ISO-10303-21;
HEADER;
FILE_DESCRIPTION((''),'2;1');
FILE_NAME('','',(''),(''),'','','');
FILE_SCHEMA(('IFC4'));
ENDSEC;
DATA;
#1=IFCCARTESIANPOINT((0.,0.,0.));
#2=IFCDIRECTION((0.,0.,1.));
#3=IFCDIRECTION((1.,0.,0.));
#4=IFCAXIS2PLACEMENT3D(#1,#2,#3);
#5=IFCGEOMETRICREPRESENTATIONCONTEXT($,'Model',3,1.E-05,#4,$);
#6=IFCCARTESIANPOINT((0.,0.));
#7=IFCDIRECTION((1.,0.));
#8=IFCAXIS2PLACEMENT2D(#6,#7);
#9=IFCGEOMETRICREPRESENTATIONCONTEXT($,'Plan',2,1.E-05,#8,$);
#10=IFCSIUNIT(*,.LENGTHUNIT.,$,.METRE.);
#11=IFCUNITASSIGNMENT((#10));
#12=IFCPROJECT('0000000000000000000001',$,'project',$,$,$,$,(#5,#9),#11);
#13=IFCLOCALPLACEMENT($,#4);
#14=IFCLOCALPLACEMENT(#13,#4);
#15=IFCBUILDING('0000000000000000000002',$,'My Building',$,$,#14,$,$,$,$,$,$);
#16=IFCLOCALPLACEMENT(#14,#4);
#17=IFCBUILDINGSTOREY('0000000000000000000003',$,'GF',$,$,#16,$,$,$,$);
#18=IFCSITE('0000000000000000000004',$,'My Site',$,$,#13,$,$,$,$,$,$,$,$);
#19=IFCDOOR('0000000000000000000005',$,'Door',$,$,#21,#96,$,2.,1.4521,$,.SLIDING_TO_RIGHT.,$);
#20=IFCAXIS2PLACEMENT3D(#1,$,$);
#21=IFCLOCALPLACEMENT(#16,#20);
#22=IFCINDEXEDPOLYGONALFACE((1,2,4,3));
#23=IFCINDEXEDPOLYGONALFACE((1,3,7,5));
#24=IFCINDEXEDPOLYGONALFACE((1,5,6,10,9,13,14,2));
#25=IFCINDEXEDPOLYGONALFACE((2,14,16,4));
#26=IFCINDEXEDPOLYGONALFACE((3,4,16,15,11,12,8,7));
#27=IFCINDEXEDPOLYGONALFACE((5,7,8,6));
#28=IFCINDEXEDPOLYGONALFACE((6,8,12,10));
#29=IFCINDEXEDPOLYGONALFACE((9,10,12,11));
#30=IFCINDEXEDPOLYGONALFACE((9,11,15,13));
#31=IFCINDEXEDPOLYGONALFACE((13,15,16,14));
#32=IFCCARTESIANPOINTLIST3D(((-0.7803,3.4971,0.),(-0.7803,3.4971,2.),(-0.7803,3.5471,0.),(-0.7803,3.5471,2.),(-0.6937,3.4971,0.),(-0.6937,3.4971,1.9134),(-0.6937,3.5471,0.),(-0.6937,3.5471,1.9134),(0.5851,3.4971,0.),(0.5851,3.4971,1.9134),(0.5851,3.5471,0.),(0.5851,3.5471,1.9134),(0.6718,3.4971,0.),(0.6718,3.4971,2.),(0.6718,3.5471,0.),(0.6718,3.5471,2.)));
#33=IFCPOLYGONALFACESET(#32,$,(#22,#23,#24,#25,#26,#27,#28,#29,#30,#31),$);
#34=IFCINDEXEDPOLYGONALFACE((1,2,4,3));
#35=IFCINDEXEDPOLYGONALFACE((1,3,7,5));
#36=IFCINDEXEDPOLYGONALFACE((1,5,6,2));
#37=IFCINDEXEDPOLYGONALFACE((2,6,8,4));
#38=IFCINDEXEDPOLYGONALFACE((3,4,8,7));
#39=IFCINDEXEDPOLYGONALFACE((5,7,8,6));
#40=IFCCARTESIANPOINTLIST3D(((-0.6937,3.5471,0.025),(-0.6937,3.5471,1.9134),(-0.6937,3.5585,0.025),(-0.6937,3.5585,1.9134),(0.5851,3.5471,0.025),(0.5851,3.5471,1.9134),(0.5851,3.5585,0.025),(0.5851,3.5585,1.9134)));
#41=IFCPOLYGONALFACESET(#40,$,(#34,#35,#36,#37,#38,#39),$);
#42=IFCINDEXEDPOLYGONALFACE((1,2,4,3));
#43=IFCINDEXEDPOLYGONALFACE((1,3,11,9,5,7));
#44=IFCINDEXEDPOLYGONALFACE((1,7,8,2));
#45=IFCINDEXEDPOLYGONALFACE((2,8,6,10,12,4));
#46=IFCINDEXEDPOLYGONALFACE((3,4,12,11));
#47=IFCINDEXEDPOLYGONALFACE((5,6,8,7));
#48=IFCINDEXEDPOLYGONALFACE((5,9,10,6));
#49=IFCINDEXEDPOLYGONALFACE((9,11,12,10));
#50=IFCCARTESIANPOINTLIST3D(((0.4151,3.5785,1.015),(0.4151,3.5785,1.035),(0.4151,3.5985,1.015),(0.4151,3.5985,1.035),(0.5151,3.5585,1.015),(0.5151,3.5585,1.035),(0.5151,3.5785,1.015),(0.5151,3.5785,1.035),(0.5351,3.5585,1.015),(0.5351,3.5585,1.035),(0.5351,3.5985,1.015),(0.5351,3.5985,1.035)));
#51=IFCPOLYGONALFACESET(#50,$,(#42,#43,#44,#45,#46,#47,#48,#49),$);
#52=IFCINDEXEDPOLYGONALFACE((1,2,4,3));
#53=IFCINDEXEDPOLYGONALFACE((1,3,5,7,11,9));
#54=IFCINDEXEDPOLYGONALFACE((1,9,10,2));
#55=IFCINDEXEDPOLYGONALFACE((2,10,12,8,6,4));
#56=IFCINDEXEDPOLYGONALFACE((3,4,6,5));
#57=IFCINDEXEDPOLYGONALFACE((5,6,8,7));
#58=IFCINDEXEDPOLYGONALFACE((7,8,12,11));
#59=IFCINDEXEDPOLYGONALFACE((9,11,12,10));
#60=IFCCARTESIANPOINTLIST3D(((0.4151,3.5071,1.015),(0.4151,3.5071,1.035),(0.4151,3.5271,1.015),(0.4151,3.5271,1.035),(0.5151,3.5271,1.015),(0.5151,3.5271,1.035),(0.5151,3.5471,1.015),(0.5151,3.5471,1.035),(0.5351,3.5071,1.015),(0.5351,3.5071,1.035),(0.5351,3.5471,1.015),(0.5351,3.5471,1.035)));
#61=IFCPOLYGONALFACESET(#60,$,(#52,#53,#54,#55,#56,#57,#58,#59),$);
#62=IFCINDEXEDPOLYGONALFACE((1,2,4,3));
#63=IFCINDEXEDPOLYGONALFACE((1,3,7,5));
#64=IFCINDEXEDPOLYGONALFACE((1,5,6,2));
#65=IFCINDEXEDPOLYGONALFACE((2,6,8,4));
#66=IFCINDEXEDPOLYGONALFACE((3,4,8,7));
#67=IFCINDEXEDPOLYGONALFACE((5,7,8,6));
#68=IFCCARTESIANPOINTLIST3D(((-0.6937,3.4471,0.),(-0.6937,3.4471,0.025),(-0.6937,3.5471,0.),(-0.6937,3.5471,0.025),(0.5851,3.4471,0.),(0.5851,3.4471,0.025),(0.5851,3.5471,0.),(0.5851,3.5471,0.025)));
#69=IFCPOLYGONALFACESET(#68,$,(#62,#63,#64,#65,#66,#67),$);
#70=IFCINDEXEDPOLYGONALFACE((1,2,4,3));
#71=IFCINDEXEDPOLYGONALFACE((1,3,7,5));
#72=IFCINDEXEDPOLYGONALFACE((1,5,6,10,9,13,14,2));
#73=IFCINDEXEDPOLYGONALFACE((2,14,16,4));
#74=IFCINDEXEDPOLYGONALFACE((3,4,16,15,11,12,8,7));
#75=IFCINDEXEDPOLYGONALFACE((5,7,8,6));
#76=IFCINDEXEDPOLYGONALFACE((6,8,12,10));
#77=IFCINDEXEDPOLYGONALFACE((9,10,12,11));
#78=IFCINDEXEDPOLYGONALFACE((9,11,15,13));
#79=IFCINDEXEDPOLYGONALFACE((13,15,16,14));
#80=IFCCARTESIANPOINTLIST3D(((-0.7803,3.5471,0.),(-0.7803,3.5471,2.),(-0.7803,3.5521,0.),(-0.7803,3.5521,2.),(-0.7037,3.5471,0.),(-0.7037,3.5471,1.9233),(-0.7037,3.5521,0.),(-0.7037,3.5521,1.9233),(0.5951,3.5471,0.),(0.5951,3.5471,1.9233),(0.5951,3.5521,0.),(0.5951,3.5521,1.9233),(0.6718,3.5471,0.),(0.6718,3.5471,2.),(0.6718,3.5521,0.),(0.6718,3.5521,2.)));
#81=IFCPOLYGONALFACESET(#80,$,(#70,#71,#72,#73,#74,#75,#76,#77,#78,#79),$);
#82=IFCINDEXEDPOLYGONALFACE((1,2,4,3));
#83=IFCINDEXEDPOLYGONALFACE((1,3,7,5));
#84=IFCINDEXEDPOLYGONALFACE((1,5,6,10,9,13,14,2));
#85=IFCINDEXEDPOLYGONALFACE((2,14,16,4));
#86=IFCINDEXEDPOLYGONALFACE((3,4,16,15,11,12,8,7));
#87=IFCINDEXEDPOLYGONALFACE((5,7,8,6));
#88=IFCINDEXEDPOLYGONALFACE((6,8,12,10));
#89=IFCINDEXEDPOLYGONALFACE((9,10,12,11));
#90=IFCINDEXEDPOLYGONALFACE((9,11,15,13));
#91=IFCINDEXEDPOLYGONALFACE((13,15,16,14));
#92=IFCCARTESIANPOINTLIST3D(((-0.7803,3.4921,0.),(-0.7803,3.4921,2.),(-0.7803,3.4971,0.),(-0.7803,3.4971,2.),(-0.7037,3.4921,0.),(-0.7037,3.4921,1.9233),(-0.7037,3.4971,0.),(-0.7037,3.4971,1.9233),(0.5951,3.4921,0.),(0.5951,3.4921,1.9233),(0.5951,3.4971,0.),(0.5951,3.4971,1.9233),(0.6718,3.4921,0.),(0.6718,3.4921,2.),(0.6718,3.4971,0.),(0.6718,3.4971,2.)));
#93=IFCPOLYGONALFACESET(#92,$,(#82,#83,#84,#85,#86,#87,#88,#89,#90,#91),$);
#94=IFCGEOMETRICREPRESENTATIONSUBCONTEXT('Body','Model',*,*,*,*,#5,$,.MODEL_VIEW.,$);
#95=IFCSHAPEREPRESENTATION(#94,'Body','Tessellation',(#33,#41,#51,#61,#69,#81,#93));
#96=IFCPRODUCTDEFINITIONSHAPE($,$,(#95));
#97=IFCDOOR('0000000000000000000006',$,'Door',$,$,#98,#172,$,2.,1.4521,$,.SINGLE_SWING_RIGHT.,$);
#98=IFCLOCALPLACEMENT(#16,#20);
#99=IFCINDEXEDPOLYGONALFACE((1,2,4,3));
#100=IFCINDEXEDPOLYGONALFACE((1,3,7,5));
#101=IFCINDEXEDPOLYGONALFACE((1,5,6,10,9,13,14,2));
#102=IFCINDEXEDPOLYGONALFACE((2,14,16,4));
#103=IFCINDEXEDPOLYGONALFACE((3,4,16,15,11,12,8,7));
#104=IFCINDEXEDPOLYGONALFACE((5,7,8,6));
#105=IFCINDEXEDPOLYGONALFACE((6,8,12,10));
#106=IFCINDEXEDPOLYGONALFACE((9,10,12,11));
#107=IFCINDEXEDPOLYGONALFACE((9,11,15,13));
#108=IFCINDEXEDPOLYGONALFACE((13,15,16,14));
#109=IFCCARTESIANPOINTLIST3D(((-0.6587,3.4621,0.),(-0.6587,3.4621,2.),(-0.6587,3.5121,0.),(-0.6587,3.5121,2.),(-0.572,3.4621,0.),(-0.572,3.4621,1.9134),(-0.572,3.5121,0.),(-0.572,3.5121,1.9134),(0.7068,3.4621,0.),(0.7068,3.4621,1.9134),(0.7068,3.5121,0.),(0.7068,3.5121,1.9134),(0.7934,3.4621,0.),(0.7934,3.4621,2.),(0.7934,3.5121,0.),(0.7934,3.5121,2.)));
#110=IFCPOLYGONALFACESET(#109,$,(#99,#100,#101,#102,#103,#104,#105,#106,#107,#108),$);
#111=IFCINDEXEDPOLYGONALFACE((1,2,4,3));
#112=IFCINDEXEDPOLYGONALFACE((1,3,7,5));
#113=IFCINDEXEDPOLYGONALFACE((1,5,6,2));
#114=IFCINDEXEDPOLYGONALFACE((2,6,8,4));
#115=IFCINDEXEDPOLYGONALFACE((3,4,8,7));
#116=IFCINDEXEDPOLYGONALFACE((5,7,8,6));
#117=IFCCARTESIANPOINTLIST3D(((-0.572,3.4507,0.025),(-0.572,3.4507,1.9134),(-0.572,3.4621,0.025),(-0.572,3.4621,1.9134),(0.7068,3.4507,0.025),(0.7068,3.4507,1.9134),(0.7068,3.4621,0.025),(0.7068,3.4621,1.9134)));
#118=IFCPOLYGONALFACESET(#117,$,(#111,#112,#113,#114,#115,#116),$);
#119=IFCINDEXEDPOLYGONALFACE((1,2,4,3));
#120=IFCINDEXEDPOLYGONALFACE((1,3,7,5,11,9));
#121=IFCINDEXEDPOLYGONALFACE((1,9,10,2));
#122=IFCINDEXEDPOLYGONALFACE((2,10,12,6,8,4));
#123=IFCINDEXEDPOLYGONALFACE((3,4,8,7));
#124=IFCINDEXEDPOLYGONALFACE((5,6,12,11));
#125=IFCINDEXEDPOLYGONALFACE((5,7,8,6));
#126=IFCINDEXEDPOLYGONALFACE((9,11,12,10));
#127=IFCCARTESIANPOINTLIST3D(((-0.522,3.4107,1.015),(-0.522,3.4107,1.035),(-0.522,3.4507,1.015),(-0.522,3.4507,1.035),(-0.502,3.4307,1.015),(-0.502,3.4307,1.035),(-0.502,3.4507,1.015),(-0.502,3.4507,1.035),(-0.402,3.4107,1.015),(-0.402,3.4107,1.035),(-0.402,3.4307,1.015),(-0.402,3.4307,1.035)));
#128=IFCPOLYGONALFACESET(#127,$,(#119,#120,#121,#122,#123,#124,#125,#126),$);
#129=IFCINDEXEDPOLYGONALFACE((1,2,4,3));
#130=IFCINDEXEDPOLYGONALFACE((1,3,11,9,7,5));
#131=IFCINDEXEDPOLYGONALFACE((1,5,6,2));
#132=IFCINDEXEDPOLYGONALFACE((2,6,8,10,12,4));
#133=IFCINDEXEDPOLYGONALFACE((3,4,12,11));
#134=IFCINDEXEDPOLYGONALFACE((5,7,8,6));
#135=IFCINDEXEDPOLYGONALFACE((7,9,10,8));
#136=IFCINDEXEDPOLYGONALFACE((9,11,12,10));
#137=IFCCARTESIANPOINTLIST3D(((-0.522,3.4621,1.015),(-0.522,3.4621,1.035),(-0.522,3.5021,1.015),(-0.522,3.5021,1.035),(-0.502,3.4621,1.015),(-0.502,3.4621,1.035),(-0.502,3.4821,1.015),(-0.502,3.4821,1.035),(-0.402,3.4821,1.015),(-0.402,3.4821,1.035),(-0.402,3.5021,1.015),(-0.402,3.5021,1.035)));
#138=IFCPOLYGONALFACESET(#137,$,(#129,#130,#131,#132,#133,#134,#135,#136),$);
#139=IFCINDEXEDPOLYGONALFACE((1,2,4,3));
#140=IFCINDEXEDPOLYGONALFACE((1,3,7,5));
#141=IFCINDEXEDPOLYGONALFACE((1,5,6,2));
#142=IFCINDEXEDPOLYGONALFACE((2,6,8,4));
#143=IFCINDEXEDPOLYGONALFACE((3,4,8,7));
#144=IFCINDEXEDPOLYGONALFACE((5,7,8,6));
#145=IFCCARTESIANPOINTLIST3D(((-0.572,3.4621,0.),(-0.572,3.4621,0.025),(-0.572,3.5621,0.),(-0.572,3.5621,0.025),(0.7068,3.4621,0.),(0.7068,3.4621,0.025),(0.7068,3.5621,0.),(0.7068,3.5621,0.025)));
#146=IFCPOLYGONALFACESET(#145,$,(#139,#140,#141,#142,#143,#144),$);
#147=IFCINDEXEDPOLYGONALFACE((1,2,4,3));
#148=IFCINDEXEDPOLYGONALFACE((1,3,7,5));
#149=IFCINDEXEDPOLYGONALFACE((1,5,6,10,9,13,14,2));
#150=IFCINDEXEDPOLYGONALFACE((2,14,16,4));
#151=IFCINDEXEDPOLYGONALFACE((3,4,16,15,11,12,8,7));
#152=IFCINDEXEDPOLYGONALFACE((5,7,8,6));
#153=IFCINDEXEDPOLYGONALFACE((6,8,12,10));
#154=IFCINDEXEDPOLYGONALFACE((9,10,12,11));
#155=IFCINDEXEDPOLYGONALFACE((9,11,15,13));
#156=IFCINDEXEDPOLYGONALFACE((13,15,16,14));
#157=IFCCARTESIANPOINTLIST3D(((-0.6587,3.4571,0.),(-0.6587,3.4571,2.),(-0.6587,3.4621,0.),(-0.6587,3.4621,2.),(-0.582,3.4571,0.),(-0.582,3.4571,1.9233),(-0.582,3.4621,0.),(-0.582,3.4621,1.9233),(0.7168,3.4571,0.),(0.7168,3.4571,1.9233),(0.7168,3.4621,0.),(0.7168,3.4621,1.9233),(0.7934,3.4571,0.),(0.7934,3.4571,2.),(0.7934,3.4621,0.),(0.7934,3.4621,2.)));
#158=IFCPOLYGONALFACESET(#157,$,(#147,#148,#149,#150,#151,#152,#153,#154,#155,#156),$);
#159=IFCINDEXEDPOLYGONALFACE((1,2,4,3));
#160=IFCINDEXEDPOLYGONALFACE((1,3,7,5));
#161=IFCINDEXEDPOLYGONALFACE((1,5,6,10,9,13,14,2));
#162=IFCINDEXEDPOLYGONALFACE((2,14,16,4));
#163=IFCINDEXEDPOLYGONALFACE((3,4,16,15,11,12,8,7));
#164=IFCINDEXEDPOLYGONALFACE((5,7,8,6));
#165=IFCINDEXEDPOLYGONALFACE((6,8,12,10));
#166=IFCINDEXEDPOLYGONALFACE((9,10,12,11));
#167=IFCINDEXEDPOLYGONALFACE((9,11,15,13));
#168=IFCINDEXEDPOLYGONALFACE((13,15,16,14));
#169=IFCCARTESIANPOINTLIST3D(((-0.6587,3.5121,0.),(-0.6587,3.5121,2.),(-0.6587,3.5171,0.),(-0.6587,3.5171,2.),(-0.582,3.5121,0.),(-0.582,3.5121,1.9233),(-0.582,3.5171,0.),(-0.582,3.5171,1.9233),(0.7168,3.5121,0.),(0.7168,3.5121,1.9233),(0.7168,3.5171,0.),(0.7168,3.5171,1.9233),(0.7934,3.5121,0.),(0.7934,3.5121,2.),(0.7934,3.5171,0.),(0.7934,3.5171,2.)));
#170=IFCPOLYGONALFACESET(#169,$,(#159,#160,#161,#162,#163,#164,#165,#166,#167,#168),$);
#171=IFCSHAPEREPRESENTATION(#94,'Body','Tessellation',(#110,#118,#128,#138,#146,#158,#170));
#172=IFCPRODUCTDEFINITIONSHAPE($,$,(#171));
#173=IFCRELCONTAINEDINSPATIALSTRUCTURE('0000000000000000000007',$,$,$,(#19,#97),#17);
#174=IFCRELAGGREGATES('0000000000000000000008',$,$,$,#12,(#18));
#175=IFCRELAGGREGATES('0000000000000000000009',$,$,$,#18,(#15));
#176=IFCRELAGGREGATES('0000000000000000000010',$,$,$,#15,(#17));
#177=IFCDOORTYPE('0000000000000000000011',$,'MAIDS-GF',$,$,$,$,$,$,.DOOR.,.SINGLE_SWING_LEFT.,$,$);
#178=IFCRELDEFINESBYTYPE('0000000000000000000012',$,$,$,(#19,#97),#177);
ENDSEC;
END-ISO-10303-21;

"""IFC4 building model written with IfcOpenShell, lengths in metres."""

from ifc_helpers import new_model, entity, si_unit, frame, origin_with_axes, origin_2d_with_axis, place, context, subcontext, project, spatial, line, indexed_curve, outline, extrude, shape, source, transform, mapped, type_object, type_shapes, element, save


model = new_model("IFC4")

# Units and contexts
model_context = context("Model", 3, precision=1e-05, world=origin_with_axes())
plan_context = context("Plan", 2, precision=1e-05, world=origin_2d_with_axis())
body_context_1 = subcontext(model_context, "Body", "Model", "MODEL_VIEW")
body_context_2 = subcontext(plan_context, "Body", "Plan", "PLAN_VIEW")
ifc_project = project(units=[si_unit("LENGTHUNIT", "METRE")], contexts=[model_context, plan_context])

# Site, building, storey
site_placement = place(None, origin_with_axes())
site = spatial("IfcSite", under=ifc_project, at=site_placement, Name="My Site")
building_placement = place(site_placement, origin_with_axes())
building = spatial("IfcBuilding", under=site, at=building_placement, Name="My Building")
storey_placement = place(building_placement, origin_with_axes())
storey = spatial("IfcBuildingStorey", under=building, at=storey_placement, Name="GF")

# Shared definitions
wall_1_placement = place(storey_placement, frame((0.7783, 3.5621, 0.0), z_axis=(0.0, 0.0, 1.0), x_axis=(-1.0, 0.0, 0.0)))
door_type_1 = type_object("IfcDoorType", Name="MAIDS-GF", OperationType="SINGLE_SWING_LEFT", PredefinedType="DOOR")
shared_shape_1 = source(origin_with_axes(), body_context_1, "Body", "SweptSolid", [
    extrude(outline(indexed_curve([(0.0, 0.0), (0.0, 2.0), (1.4521, 2.0), (1.4521, 0.0), (1.3655, 0.0), (1.3655, 1.9134), (0.0866, 1.9134), (0.0866, 0.0)], segments=[line(1, 2, 3, 4, 5, 6, 7, 8, 1)])), frame((0.0, 0.0, 0.0), z_axis=(0.0, -1.0, 0.0), x_axis=(1.0, 0.0, 0.0)), (0.0, 0.0, -1.0), 0.05),
    extrude(outline(indexed_curve([(0.0, 0.0), (1.2788, 0.0), (1.2788, 0.0114), (0.0, 0.0114)], segments=[line(1, 2, 3, 4, 1)])), frame((0.0866, -0.0114, 0.025), z_axis=(0.0, 0.0, 1.0), x_axis=(1.0, 0.0, 0.0)), (0.0, 0.0, 1.0), 1.8884),
    extrude(outline(indexed_curve([(0.0, 0.0), (0.0, -0.04), (0.12, -0.04), (0.12, -0.02), (0.02, -0.02), (0.02, 0.0)], segments=[line(1, 2, 3, 4, 5, 6, 1)])), frame((0.1366, -0.0114, 1.015), z_axis=(0.0, 0.0, 1.0), x_axis=(1.0, 0.0, 0.0)), (0.0, 0.0, 1.0), 0.02),
    extrude(outline(indexed_curve([(0.0, 0.0), (0.0, 0.04), (0.12, 0.04), (0.12, 0.02), (0.02, 0.02), (0.02, 0.0)], segments=[line(1, 2, 3, 4, 5, 6, 1)])), frame((0.1366, 0.0, 1.015), z_axis=(0.0, 0.0, 1.0), x_axis=(1.0, 0.0, 0.0)), (0.0, 0.0, 1.0), 0.02),
    extrude(outline(indexed_curve([(0.0, 0.0), (1.2788, 0.0), (1.2788, 0.1), (0.0, 0.1)], segments=[line(1, 2, 3, 4, 1)])), frame((0.0866, 0.0, 0.0), z_axis=(0.0, 0.0, 1.0), x_axis=(1.0, 0.0, 0.0)), (0.0, 0.0, 1.0), 0.025),
    extrude(outline(indexed_curve([(0.0, 0.0), (0.0, 2.0), (1.4521, 2.0), (1.4521, 0.0), (1.3754, 0.0), (1.3754, 1.9233), (0.0767, 1.9233), (0.0767, 0.0)], segments=[line(1, 2, 3, 4, 5, 6, 7, 8, 1)])), frame((0.0, -0.005, 0.0), z_axis=(0.0, -1.0, 0.0), x_axis=(1.0, 0.0, 0.0)), (0.0, 0.0, -1.0), 0.005),
    extrude(outline(indexed_curve([(0.0, 0.0), (0.0, 2.0), (1.4521, 2.0), (1.4521, 0.0), (1.3754, 0.0), (1.3754, 1.9233), (0.0767, 1.9233), (0.0767, 0.0)], segments=[line(1, 2, 3, 4, 5, 6, 7, 8, 1)])), frame((0.0, 0.05, 0.0), z_axis=(0.0, -1.0, 0.0), x_axis=(1.0, 0.0, 0.0)), (0.0, 0.0, -1.0), 0.005),
])
shared_shape_2 = source(origin_with_axes(), body_context_2, "Body", "Curve2D", [
    entity("IfcIndexedPolyCurve", entity("IfcCartesianPointList2D", [[0.0, 0.0], [0.0866, 0.0], [0.0866, 0.05], [0.0, 0.05]]), [entity("IfcLineIndex", [1, 2, 3, 4, 1])]),
    entity("IfcIndexedPolyCurve", entity("IfcCartesianPointList2D", [[1.4521, 0.0], [1.3655, 0.0], [1.3655, 0.05], [1.4521, 0.05]]), [entity("IfcLineIndex", [1, 2, 3, 4, 1])]),
    entity("IfcIndexedPolyCurve", entity("IfcCartesianPointList2D", [[2.0049, -0.0114], [0.7261, -0.0114], [0.7261, 0.0], [2.0049, 0.0]]), [entity("IfcLineIndex", [1, 2, 3, 4, 1])]),
])
type_shapes(door_type_1, [shared_shape_1, shared_shape_2])

# Doors
placement_1 = place(wall_1_placement, frame((0.1066, 0.015, 0.0), z_axis=(0.0, 0.0, 1.0), x_axis=(1.0, 0.0, 0.0)))
door_1_placement = place(placement_1, origin_with_axes())
element("IfcDoor", 1, at=door_1_placement, inside=storey, type_object=door_type_1, Name="Door", OperationType="SLIDING_TO_RIGHT", OverallHeight=2.0, OverallWidth=1.4521, shapes=[
    shape(body_context_1, "Body", "MappedRepresentation", [mapped(shared_shape_1, transform((0.0, 0.0, 0.0), x_axis=(1.0, 0.0, 0.0), y_axis=(0.0, 1.0, 0.0), z_axis=(0.0, 0.0, 1.0), scale=1.0))]),
    shape(body_context_2, "Body", "MappedRepresentation", [mapped(shared_shape_2, transform((0.0, 0.0, 0.0), x_axis=(1.0, 0.0, 0.0), y_axis=(0.0, 1.0, 0.0), z_axis=(0.0, 0.0, 1.0), scale=1.0))]),
])
placement_2 = place(wall_1_placement, frame((1.437, 0.1, 0.0), z_axis=(0.0, 0.0, 1.0), x_axis=(-1.0, 0.0, 0.0)))
door_2_placement = place(placement_2, frame((0.0, 0.0, 0.0), z_axis=(0.0, 0.0, 1.0), x_axis=(1.0, 0.0, 0.0)))
element("IfcDoor", 2, at=door_2_placement, inside=storey, type_object=door_type_1, Name="Door", OperationType="SINGLE_SWING_RIGHT", OverallHeight=2.0, OverallWidth=1.4521, shapes=[
    shape(body_context_1, "Body", "MappedRepresentation", [mapped(shared_shape_1, transform((0.0, 0.0, 0.0), x_axis=(1.0, 0.0, 0.0), y_axis=(0.0, 1.0, 0.0), z_axis=(0.0, 0.0, 1.0), scale=1.0))]),
    shape(body_context_2, "Body", "MappedRepresentation", [mapped(shared_shape_2, transform((0.0, 0.0, 0.0), x_axis=(1.0, 0.0, 0.0), y_axis=(0.0, 1.0, 0.0), z_axis=(0.0, 0.0, 1.0), scale=1.0))]),
])

save(model, "model.ifc")
